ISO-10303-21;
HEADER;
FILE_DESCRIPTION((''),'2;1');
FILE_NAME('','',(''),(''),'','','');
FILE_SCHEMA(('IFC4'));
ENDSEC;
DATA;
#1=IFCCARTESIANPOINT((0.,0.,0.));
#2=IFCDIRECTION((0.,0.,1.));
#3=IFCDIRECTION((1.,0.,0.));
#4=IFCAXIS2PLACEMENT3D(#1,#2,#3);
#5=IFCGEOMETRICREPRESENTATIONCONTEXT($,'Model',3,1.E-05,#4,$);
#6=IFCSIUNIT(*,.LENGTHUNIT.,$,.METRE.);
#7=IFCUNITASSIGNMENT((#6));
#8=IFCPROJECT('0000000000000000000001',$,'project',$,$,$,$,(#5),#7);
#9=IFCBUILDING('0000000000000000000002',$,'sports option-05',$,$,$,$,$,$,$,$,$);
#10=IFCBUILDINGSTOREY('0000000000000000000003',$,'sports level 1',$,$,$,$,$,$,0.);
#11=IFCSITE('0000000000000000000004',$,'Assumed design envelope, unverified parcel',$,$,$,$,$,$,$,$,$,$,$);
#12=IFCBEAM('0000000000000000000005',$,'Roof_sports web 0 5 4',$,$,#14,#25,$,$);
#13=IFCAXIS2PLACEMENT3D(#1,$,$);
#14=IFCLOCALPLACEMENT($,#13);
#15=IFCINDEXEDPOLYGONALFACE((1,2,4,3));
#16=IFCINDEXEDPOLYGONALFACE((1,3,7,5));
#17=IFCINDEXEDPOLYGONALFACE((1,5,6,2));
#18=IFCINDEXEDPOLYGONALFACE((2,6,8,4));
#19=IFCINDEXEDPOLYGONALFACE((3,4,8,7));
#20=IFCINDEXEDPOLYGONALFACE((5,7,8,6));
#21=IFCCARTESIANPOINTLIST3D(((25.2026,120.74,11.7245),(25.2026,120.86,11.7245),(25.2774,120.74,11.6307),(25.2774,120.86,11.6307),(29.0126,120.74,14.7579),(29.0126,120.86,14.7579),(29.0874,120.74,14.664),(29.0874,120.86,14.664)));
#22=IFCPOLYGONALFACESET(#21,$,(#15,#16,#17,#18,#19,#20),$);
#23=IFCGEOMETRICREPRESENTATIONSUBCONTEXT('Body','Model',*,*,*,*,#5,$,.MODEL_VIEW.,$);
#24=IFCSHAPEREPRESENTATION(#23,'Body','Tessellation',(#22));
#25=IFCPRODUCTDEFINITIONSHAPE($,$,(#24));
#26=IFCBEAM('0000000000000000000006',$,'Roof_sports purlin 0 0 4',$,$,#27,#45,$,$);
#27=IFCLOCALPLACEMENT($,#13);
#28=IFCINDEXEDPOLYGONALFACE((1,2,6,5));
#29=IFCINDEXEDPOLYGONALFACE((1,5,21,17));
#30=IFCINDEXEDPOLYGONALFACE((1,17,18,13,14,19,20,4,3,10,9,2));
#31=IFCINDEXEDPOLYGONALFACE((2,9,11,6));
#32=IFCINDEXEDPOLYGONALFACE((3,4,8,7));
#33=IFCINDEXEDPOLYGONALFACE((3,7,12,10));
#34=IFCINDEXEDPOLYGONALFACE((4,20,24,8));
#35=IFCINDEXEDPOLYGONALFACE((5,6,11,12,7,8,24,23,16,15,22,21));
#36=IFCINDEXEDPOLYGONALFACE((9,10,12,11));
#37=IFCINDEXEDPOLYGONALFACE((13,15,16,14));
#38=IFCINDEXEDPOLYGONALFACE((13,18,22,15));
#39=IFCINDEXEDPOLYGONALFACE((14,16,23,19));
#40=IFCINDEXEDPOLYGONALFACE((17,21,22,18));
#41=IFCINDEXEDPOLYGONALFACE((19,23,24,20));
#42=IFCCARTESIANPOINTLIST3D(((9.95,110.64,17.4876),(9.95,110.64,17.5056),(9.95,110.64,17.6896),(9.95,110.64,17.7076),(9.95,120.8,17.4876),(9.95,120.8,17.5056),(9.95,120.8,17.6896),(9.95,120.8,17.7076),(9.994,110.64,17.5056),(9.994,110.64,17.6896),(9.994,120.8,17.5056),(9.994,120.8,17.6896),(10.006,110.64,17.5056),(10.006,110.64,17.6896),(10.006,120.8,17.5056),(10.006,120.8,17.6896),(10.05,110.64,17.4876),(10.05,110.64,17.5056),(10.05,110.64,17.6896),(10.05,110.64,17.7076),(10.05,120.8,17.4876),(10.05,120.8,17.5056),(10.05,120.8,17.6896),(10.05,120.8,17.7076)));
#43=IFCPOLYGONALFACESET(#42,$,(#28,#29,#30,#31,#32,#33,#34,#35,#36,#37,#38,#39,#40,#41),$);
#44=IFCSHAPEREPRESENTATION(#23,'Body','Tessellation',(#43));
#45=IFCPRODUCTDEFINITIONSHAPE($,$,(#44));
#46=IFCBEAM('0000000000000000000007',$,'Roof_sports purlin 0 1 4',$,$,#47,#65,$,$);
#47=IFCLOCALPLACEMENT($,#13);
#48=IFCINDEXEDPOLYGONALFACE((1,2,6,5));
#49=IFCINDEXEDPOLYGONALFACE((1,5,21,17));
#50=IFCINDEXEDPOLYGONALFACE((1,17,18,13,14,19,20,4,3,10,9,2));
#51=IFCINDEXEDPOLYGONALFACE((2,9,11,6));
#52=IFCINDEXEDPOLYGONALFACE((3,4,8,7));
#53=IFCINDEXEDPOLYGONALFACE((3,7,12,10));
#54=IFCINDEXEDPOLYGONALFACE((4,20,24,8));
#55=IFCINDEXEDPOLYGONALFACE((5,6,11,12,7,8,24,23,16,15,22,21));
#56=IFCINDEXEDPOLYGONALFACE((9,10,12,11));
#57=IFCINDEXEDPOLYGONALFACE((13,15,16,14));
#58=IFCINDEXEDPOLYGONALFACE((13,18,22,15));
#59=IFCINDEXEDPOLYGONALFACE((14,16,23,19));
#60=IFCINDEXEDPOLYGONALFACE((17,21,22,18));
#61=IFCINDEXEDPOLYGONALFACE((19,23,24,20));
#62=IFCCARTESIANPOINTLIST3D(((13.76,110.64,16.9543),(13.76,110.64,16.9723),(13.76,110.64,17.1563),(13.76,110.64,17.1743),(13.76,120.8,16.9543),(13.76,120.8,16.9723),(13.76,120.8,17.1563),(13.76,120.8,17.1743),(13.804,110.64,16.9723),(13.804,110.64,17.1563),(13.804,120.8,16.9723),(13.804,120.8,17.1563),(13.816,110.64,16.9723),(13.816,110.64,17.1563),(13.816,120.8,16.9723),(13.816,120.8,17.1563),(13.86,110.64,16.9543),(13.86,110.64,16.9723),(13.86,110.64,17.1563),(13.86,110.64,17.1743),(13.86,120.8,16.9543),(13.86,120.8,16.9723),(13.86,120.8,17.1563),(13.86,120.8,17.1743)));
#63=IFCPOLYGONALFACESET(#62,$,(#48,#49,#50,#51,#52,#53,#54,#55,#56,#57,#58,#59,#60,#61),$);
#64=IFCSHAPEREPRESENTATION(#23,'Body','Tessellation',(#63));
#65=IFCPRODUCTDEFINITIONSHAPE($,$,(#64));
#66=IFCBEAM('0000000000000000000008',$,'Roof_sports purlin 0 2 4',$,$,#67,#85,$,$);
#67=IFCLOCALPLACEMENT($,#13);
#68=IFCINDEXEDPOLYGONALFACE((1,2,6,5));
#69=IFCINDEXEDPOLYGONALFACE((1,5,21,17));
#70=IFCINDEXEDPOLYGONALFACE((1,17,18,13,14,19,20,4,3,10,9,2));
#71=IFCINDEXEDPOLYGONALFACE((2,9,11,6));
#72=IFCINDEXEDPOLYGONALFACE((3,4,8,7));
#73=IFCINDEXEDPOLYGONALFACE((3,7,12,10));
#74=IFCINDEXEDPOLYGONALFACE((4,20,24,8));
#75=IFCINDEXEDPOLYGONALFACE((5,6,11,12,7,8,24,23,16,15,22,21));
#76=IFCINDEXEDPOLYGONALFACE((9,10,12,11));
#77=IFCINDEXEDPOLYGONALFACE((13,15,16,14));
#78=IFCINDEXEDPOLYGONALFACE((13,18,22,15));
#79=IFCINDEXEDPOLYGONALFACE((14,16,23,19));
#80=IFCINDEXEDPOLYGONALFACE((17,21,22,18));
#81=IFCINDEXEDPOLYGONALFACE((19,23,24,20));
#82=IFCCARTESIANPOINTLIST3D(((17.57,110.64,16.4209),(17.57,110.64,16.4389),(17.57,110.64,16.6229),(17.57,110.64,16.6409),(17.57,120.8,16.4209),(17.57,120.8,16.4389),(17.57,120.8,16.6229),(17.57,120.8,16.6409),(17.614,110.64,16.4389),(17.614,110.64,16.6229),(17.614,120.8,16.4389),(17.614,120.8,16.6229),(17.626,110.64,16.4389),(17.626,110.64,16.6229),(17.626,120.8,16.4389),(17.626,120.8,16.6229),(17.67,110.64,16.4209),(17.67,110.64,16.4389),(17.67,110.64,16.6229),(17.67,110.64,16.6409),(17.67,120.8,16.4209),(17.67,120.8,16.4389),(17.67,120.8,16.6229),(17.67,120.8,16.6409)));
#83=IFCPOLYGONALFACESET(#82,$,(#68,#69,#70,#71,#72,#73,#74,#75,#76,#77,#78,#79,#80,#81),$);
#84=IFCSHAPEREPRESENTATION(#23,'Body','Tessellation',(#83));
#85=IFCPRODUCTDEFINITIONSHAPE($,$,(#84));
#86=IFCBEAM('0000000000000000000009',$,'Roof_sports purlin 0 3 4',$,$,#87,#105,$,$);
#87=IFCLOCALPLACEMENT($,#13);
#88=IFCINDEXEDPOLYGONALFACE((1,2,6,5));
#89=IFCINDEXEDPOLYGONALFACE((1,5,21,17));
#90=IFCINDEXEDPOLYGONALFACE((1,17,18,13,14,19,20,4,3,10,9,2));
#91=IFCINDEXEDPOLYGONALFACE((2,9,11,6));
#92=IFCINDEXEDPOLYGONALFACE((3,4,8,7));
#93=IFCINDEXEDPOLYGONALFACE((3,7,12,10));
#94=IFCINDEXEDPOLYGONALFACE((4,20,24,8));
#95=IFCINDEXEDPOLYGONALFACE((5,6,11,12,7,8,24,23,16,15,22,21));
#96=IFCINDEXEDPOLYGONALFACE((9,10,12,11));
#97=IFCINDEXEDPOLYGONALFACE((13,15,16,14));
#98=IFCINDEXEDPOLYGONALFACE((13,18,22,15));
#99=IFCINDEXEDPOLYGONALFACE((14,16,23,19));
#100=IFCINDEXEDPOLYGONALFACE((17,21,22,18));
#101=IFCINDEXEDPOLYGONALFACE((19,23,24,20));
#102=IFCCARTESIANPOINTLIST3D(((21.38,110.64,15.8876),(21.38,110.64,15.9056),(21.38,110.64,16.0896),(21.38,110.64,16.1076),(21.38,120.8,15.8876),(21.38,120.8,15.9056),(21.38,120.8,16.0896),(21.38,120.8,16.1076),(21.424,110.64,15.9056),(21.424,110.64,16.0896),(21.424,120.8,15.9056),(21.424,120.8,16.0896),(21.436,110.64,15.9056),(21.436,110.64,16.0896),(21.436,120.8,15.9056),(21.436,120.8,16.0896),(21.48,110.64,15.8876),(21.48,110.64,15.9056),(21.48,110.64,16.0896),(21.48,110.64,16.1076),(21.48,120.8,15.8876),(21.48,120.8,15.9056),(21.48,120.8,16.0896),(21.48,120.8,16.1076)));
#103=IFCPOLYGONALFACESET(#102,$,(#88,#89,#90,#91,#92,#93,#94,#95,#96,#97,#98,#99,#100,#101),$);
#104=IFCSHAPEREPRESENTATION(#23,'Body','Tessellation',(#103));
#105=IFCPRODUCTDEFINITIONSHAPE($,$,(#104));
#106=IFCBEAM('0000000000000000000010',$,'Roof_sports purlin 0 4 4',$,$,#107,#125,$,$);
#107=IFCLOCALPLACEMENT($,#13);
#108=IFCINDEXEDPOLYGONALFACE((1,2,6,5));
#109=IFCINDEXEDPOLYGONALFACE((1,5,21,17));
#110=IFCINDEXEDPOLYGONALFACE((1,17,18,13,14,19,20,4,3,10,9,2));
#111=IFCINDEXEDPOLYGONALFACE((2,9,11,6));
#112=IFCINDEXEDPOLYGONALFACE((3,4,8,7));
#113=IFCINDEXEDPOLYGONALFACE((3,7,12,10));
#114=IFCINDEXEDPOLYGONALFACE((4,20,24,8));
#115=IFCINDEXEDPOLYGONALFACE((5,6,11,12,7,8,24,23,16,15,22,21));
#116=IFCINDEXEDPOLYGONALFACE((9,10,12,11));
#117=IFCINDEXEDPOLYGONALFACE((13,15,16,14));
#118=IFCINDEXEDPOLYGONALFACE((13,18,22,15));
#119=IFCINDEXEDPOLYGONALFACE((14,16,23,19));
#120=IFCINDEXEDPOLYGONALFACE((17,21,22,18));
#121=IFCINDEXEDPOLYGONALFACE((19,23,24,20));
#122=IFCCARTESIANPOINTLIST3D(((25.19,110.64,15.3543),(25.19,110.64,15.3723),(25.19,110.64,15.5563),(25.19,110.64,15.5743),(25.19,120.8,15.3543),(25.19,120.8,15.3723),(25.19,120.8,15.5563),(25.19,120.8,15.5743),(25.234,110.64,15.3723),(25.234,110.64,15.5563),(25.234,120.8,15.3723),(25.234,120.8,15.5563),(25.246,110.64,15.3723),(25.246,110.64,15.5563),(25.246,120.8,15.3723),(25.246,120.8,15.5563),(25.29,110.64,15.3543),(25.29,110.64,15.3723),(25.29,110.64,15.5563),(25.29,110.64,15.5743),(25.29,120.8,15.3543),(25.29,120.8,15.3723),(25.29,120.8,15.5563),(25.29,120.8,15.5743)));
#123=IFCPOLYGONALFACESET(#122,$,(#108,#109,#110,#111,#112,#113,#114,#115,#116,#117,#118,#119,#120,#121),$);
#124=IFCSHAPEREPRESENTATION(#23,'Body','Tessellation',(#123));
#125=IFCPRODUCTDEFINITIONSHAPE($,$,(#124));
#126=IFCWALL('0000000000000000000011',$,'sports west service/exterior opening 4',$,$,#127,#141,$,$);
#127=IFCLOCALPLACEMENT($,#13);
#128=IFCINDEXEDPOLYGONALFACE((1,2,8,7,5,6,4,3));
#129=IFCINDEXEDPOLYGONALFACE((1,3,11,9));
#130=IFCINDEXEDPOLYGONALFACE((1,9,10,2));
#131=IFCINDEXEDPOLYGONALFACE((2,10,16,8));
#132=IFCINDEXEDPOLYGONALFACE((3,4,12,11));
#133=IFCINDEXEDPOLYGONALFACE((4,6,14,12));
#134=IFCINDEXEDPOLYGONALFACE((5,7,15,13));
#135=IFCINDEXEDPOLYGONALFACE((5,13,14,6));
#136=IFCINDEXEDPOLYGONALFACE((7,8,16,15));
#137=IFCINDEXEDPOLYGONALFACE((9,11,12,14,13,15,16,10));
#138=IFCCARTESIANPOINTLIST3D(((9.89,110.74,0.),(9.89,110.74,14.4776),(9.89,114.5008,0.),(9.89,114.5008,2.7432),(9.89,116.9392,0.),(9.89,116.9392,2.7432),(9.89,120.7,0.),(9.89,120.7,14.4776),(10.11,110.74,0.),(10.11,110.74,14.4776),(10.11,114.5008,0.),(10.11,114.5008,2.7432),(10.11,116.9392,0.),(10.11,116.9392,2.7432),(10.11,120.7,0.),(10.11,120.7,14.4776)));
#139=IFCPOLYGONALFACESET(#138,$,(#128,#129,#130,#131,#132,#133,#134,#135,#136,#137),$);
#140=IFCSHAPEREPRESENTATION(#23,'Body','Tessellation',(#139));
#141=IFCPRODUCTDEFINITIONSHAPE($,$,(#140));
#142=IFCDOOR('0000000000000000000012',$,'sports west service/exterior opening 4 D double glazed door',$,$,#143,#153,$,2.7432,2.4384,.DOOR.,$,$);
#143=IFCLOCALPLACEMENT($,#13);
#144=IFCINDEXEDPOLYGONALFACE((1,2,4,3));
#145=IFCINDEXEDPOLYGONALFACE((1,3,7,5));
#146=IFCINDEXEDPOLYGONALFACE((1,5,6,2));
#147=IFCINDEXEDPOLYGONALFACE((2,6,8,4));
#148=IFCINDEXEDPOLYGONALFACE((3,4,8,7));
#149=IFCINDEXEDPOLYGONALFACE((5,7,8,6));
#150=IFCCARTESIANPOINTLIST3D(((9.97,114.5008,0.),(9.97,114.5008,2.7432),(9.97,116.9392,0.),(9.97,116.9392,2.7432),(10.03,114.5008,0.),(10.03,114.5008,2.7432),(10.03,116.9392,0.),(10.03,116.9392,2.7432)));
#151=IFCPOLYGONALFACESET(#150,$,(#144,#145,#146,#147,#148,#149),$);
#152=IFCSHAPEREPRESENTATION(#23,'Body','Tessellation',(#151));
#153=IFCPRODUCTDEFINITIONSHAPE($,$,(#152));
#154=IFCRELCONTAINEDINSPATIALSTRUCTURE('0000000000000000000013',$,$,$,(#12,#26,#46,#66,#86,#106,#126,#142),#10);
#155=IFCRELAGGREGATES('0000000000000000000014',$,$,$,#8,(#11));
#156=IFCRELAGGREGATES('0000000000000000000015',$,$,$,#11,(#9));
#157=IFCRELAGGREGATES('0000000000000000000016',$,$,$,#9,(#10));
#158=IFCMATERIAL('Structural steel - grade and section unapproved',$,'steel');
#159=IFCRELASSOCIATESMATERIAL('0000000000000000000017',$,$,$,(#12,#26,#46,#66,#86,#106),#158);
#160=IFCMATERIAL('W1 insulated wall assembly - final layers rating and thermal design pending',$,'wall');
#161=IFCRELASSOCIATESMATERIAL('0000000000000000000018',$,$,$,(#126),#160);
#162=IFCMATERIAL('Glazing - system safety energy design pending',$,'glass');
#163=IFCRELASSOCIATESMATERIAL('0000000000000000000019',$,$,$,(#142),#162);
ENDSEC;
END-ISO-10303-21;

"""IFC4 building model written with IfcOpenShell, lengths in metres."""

from ifc_helpers import new_model, si_unit, frame, origin_with_axes, place, context, subcontext, project, spatial, rectangle, i_section, extrude, material, element, fill, save


model = new_model("IFC4")

# Units and contexts
model_context = context("Model", 3, precision=1e-05, world=origin_with_axes())
body_context = subcontext(model_context, "Body", "Model", "MODEL_VIEW")
ifc_project = project(units=[si_unit("LENGTHUNIT", "METRE")], contexts=[model_context])

# Site, building, storey
site = spatial("IfcSite", under=ifc_project, Name="Assumed design envelope, unverified parcel")
building = spatial("IfcBuilding", under=site, Name="sports option-05")
storey = spatial("IfcBuildingStorey", under=building, Name="sports level 1", Elevation=0.0)

# Shared definitions
ifc_material_1 = material(Name="Structural steel - grade and section unapproved", Category="steel")

# Beams
beam_1_placement = place(None, frame((25.24, 120.8, 11.6776), z_axis=(0.782336, 0.0, 0.622857), x_axis=(0.0, 1.0, 0.0)))
element("IfcBeam", 1, at=beam_1_placement, inside=storey, material=ifc_material_1, Name="Roof_sports web 0 5 4", context=body_context, shape_type="SweptSolid", body=[
    extrude(rectangle(XDim=0.12, YDim=0.12), origin_with_axes(), (0.0, 0.0, 1.0), 4.87),
])
for number, where, z_axis, x_axis, name in (
    (2, (10.0, 110.64, 17.5976), (0.0, 1.0, 0.0), (-1.0, 0.0, 0.0), "Roof_sports purlin 0 0 4"),
    (3, (13.81, 110.64, 17.0643), (0.0, 1.0, 0.0), (-1.0, 0.0, 0.0), "Roof_sports purlin 0 1 4"),
    (4, (17.62, 110.64, 16.5309), (0.0, 1.0, 0.0), (-1.0, 0.0, 0.0), "Roof_sports purlin 0 2 4"),
    (5, (21.43, 110.64, 15.9976), (0.0, 1.0, 0.0), (-1.0, 0.0, 0.0), "Roof_sports purlin 0 3 4"),
    (6, (25.24, 110.64, 15.4643), (0.0, 1.0, 0.0), (-1.0, 0.0, 0.0), "Roof_sports purlin 0 4 4"),
):
    element("IfcBeam", number, at=place(None, frame(where, z_axis=z_axis, x_axis=x_axis)), inside=storey, material=ifc_material_1, Name=name, context=body_context, shape_type="SweptSolid", body=[
        extrude(i_section(OverallWidth=0.1, OverallDepth=0.22, WebThickness=0.012, FlangeThickness=0.018, FilletRadius=0.0), origin_with_axes(), (0.0, 0.0, 1.0), 10.16),
    ])

# Wall, opening, door
ifc_material_2 = material(Name="W1 insulated wall assembly - final layers rating and thermal design pending", Category="wall")
wall_placement = place(None, frame((10.0, 115.72, 0.0), z_axis=(0.0, 0.0, 1.0), x_axis=(0.0, 1.0, 0.0)))
wall = element("IfcWall", 7, at=wall_placement, inside=storey, material=ifc_material_2, Name="sports west service/exterior opening 4", context=body_context, shape_type="SweptSolid", body=[
    extrude(rectangle(XDim=9.96, YDim=0.22), origin_with_axes(), (0.0, 0.0, 1.0), 14.4776),
])
opening_placement = place(None, frame((10.0, 115.72, 0.0), z_axis=(0.0, 0.0, 1.0), x_axis=(0.0, 1.0, 0.0)))
opening = element("IfcOpeningElement", 8, at=opening_placement, cuts=wall, context=body_context, shape_type="SweptSolid", body=[
    extrude(rectangle(XDim=2.4384, YDim=0.32), origin_with_axes(), (0.0, 0.0, 1.0), 2.7432),
])
ifc_material_3 = material(Name="Glazing - system safety energy design pending", Category="glass")
door_placement = place(None, frame((10.0, 115.72, 0.0), z_axis=(0.0, 0.0, 1.0), x_axis=(0.0, 1.0, 0.0)))
door = element("IfcDoor", 9, at=door_placement, inside=storey, material=ifc_material_3, Name="sports west service/exterior opening 4 D double glazed door", OverallHeight=2.7432, OverallWidth=2.4384, PredefinedType="DOOR", context=body_context, shape_type="SweptSolid", body=[
    extrude(rectangle(XDim=2.4384, YDim=0.06), origin_with_axes(), (0.0, 0.0, 1.0), 2.7432),
])
fill(opening, door)

save(model, "model.ifc")
